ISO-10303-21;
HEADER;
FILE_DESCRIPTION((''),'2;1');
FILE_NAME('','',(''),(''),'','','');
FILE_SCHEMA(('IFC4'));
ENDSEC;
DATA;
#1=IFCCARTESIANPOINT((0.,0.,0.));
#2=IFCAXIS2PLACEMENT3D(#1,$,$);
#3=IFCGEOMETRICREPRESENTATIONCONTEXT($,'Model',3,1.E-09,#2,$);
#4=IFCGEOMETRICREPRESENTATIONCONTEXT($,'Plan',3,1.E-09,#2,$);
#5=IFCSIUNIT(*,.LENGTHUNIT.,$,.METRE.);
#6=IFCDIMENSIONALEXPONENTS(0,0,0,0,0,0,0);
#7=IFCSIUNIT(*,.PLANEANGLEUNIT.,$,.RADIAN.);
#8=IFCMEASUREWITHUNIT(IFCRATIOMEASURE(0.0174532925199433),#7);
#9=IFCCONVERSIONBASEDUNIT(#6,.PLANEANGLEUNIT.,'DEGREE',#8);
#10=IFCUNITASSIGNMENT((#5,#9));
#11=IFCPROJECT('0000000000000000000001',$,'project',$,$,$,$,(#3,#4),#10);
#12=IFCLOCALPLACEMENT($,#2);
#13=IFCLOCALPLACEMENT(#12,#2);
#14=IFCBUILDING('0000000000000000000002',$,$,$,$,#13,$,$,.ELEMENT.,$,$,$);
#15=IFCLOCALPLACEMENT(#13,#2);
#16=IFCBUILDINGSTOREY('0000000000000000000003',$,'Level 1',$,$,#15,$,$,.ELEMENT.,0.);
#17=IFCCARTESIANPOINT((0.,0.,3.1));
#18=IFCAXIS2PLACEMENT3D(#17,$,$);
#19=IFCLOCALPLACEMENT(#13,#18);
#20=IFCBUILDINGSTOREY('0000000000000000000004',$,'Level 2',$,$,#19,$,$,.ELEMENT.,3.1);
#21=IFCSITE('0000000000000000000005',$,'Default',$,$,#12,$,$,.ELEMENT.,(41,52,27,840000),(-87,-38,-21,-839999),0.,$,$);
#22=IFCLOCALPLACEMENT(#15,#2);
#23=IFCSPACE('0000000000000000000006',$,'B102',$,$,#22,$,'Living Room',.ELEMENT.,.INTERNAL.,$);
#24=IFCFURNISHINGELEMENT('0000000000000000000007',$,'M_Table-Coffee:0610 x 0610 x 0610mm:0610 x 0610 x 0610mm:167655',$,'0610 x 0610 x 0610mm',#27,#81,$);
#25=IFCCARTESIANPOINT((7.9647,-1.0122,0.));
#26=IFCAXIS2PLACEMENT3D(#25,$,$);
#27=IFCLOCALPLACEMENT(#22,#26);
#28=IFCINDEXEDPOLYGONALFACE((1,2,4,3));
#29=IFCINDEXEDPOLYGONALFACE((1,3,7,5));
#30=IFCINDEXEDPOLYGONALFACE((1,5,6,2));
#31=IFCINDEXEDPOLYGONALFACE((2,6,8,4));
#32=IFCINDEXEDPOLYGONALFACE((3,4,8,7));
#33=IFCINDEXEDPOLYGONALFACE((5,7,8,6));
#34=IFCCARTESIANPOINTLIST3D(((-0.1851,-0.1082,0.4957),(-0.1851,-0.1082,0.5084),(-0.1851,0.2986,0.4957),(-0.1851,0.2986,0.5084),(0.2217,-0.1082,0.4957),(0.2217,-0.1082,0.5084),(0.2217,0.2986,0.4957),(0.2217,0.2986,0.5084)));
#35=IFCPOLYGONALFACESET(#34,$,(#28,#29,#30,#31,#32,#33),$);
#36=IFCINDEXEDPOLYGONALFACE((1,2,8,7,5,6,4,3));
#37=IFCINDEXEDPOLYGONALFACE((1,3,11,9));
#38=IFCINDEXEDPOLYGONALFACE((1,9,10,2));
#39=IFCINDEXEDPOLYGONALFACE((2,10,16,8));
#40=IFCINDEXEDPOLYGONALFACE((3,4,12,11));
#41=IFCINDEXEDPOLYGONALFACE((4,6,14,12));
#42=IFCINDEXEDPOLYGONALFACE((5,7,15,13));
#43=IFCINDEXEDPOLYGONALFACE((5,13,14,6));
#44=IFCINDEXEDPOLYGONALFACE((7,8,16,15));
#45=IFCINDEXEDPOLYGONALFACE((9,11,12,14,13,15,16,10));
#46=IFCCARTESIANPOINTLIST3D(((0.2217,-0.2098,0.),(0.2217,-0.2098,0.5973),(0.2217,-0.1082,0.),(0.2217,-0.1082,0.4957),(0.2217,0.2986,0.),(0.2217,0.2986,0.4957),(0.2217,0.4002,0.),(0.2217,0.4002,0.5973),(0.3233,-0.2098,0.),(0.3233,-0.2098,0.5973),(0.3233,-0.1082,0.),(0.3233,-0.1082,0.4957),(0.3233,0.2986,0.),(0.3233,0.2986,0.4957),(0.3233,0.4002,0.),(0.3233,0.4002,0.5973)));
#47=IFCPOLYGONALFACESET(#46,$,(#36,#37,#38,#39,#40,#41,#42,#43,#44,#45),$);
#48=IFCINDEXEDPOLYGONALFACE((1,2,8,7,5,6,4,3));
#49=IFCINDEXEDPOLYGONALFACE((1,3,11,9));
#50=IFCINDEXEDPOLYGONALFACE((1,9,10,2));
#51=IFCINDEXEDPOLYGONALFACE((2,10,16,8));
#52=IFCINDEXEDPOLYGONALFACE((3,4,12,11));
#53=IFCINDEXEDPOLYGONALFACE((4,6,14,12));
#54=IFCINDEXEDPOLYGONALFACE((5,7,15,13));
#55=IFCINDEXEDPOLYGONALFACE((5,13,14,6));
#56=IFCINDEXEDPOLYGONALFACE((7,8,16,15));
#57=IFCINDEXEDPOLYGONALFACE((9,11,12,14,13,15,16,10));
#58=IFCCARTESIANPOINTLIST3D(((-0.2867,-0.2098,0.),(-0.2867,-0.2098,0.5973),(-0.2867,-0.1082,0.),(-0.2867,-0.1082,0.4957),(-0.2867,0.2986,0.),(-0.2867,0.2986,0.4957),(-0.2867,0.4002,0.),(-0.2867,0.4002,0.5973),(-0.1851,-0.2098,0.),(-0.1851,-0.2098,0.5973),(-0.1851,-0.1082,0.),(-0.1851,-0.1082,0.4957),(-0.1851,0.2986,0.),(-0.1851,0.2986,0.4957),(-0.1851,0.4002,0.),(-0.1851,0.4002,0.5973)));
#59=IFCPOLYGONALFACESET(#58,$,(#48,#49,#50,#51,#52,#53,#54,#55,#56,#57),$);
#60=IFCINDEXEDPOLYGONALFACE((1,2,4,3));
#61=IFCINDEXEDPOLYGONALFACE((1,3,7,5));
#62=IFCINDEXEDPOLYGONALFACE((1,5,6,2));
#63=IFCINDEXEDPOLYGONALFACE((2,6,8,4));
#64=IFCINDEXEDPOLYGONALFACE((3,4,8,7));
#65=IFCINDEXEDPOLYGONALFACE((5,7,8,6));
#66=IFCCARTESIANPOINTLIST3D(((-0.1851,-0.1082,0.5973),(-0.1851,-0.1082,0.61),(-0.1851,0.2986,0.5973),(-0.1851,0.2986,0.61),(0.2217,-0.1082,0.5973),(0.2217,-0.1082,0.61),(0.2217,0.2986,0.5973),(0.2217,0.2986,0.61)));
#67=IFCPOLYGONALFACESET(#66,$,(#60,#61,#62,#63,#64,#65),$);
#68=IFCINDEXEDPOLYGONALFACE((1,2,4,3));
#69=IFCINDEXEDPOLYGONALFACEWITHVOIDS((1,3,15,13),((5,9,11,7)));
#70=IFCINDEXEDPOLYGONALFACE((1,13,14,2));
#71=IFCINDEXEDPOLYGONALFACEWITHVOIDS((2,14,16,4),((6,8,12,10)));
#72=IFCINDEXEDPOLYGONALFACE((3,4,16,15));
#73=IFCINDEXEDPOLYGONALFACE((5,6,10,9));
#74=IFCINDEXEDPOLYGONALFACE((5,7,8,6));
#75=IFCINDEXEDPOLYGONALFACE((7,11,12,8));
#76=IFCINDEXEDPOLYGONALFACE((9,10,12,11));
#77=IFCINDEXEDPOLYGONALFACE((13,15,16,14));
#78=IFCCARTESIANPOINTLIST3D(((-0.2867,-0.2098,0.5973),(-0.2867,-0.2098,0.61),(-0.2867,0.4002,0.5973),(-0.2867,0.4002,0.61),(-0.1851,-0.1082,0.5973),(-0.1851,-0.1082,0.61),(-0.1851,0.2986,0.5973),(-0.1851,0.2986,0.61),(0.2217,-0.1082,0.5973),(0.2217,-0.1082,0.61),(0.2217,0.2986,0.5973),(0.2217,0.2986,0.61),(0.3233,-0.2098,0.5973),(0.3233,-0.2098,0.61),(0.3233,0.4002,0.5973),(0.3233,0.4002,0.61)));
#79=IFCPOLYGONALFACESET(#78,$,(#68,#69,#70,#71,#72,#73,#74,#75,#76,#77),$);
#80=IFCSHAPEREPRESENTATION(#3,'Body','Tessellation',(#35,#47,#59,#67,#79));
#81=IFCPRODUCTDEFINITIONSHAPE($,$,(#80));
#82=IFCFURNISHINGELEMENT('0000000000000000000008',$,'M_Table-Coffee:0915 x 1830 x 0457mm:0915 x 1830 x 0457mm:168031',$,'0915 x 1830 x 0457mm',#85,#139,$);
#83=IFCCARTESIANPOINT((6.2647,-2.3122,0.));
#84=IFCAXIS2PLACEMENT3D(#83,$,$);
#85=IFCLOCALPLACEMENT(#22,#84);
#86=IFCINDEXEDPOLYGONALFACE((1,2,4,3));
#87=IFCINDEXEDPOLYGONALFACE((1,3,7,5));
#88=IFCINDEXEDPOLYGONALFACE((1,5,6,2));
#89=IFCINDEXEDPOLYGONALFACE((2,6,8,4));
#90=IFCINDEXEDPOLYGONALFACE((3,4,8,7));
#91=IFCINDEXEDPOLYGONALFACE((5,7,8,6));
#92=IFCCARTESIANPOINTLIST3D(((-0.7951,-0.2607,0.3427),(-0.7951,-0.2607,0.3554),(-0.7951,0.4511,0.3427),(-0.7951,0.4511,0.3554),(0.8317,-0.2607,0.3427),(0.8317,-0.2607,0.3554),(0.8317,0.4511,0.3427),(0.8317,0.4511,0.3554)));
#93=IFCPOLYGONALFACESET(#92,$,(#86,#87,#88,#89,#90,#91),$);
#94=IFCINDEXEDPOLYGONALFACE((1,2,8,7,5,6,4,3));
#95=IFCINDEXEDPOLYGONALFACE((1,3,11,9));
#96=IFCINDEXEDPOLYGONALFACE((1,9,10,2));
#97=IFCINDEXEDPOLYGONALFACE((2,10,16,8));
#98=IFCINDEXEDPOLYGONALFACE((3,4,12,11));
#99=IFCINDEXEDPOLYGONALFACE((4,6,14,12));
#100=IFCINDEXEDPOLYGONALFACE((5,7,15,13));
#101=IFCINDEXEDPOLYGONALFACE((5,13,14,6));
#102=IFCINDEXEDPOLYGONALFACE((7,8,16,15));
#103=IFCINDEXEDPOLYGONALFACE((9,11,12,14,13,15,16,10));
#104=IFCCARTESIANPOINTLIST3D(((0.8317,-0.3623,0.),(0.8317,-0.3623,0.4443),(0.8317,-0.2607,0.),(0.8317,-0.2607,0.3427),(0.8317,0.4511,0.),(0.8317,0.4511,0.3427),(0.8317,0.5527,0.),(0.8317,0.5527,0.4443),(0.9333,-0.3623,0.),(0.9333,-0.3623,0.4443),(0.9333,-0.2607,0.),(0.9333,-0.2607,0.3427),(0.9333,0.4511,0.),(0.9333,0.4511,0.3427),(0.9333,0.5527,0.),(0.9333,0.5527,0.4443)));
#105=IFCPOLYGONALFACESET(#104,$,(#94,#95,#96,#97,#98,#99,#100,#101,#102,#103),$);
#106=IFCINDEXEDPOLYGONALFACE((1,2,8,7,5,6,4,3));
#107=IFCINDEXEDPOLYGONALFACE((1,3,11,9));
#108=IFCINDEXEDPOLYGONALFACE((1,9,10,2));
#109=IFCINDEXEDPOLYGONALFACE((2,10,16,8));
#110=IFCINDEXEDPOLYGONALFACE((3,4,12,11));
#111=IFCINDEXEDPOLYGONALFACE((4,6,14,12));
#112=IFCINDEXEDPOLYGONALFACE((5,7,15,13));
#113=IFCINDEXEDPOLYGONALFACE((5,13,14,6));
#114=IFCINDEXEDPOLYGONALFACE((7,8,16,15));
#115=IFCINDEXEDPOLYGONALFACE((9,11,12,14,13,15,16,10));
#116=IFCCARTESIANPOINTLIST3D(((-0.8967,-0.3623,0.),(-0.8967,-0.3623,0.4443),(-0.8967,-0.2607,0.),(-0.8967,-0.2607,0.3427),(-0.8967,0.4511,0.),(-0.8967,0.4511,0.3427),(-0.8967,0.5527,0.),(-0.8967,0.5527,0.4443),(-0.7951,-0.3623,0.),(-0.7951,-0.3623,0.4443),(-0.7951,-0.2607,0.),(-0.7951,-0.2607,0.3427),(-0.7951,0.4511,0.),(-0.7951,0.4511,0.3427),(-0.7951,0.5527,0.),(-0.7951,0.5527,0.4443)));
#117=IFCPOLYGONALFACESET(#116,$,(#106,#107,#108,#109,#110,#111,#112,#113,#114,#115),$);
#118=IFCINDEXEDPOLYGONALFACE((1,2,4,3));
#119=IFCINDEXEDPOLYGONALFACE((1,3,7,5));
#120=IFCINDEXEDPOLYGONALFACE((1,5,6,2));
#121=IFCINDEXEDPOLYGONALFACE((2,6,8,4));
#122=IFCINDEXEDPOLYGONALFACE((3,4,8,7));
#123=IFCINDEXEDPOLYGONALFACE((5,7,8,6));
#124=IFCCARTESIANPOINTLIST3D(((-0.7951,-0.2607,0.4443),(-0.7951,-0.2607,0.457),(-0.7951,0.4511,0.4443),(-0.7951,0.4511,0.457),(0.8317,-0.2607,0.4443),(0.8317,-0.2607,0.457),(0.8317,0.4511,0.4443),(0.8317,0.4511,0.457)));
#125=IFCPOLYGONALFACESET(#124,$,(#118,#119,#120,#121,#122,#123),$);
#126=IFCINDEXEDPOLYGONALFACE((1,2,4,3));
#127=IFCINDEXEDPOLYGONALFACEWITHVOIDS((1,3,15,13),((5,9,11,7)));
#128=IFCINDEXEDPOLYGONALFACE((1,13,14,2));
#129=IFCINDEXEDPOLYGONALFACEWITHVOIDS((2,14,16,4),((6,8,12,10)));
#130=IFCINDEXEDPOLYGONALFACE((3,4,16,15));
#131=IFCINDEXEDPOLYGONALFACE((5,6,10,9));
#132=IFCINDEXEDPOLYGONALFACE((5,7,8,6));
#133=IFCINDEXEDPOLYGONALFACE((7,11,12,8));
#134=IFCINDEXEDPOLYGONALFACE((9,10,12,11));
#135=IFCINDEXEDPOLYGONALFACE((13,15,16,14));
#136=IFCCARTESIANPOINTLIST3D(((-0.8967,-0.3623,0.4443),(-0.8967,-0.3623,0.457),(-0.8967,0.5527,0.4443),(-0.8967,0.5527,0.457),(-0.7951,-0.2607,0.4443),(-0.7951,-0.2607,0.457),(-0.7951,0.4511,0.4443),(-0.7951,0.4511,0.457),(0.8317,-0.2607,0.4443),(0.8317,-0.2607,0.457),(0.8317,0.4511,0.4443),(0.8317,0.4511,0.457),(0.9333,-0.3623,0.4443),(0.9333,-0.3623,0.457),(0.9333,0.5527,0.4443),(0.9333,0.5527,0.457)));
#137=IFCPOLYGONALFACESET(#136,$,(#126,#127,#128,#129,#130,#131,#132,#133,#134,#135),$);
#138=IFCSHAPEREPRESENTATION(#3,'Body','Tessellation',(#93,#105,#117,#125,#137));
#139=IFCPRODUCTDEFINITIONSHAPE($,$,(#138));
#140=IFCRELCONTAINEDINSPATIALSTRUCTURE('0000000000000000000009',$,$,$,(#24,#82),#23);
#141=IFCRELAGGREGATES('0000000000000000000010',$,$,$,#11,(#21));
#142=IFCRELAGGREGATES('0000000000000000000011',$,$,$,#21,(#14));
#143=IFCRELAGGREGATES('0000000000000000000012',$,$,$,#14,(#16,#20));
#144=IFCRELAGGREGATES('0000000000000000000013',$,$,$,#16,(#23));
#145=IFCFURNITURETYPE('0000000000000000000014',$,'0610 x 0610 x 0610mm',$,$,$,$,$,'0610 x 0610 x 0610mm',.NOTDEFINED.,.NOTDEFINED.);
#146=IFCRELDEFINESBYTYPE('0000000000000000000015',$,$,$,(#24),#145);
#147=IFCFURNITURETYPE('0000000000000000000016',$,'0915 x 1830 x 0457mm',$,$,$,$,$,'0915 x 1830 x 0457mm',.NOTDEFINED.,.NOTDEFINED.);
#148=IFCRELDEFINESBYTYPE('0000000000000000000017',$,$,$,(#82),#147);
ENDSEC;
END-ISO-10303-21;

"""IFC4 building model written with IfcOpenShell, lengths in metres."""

from ifc_helpers import new_model, entity, si_unit, converted_unit, frame, origin, origin_2d_with_axis, place, context, project, spatial, polyline, rectangle, outline, extrude, source, transform, mapped, type_object, type_shapes, element, save


model = new_model("IFC4")

# Units and contexts
model_context = context("Model", 3, precision=1e-09, world=origin())
plan_context = context("Plan", 3, precision=1e-09, world=origin())
ifc_project = project(units=[si_unit("LENGTHUNIT", "METRE"), converted_unit("PLANEANGLEUNIT", "DEGREE", entity("IfcRatioMeasure", 0.0174532925199433), si_unit("PLANEANGLEUNIT", "RADIAN"), dimensions=[0, 0, 0, 0, 0, 0, 0])], contexts=[model_context, plan_context])

# Site, building, storey
site_placement = place(None, origin())
site = spatial("IfcSite", under=ifc_project, at=site_placement, Name="Default", CompositionType="ELEMENT", RefLatitude=(41, 52, 27, 840000), RefLongitude=(-87, -38, -21, -839999), RefElevation=0.0)
building_placement = place(site_placement, origin())
building = spatial("IfcBuilding", under=site, at=building_placement, CompositionType="ELEMENT")
storey_1_placement = place(building_placement, origin())
storey_1 = spatial("IfcBuildingStorey", under=building, at=storey_1_placement, Name="Level 1", CompositionType="ELEMENT", Elevation=0.0)

# Shared definitions
storey_2_placement = place(building_placement, frame((0.0, 0.0, 3.1)))
storey_2 = spatial("IfcBuildingStorey", under=building, at=storey_2_placement, Name="Level 2", CompositionType="ELEMENT", Elevation=3.1)

# Shared definitions
space_1_placement = place(storey_1_placement, origin())
space_1 = spatial("IfcSpace", under=storey_1, at=space_1_placement, Name="B102", LongName="Living Room", CompositionType="ELEMENT", PredefinedType="INTERNAL")

# Furnishing elements
furniture_type_1 = type_object("IfcFurnitureType", Name="0610 x 0610 x 0610mm", ElementType="0610 x 0610 x 0610mm", AssemblyPlace="NOTDEFINED")
shared_shape_1 = source(origin(), model_context, "Body", "SweptSolid", [
    extrude(rectangle(XDim=0.4068, YDim=0.4068, at=origin_2d_with_axis()), frame((0.0183, 0.0952, 0.4957), z_axis=(0.0, 0.0, 1.0), x_axis=(-1.0, 0.0, 0.0)), (0.0, 0.0, 1.0), 0.0127),
    extrude(outline(polyline([(-0.2732, -0.305), (0.324, -0.305), (0.324, 0.305), (-0.2732, 0.305), (-0.2732, 0.2034), (0.2225, 0.2034), (0.2225, -0.2034), (-0.2732, -0.2034), (-0.2732, -0.305)])), frame((0.2217, 0.0952, 0.2732), z_axis=(1.0, 0.0, 0.0), x_axis=(0.0, 0.0, 1.0)), (0.0, 0.0, 1.0), 0.1016),
    extrude(outline(polyline([(-0.305, -0.3241), (0.305, -0.3241), (0.305, 0.2733), (0.2034, 0.2733), (0.2034, -0.2224), (-0.2034, -0.2224), (-0.2034, 0.2733), (-0.305, 0.2733), (-0.305, -0.3241)])), frame((-0.2867, 0.0952, 0.2733), z_axis=(1.0, 0.0, 0.0), x_axis=(0.0, -1.0, 0.0)), (0.0, 0.0, 1.0), 0.1016),
    extrude(rectangle(XDim=0.4068, YDim=0.4068, at=origin_2d_with_axis()), frame((0.0183, 0.0952, 0.5973), z_axis=(0.0, 0.0, 1.0), x_axis=(-1.0, 0.0, 0.0)), (0.0, 0.0, 1.0), 0.0127),
    extrude(outline(polyline([(-0.305, -0.305), (0.305, -0.305), (0.305, 0.305), (-0.305, 0.305), (-0.305, -0.305)]), holes=[polyline([(-0.2034, -0.2034), (-0.2034, 0.2034), (0.2034, 0.2034), (0.2034, -0.2034), (-0.2034, -0.2034)])]), frame((0.0183, 0.0952, 0.5973), z_axis=(0.0, 0.0, 1.0), x_axis=(-1.0, 0.0, 0.0)), (0.0, 0.0, 1.0), 0.0127),
])
type_shapes(furniture_type_1, [shared_shape_1])
for number, where, name in (
    (1, (7.9647, -1.0122, 0.0), "M_Table-Coffee:0610 x 0610 x 0610mm:0610 x 0610 x 0610mm:167655"),
):
    element("IfcFurnishingElement", number, at=place(space_1_placement, frame(where)), inside=space_1, type_object=furniture_type_1, Name=name, ObjectType="0610 x 0610 x 0610mm", context=model_context, shape_type="MappedRepresentation", body=[
        mapped(shared_shape_1, transform((0.0, 0.0, 0.0), scale=1.0)),
    ])
furniture_type_2 = type_object("IfcFurnitureType", Name="0915 x 1830 x 0457mm", ElementType="0915 x 1830 x 0457mm", AssemblyPlace="NOTDEFINED")
shared_shape_2 = source(origin(), model_context, "Body", "SweptSolid", [
    extrude(rectangle(XDim=1.6268, YDim=0.7118, at=origin_2d_with_axis()), frame((0.0183, 0.0952, 0.3427), z_axis=(0.0, 0.0, 1.0), x_axis=(-1.0, 0.0, 0.0)), (0.0, 0.0, 1.0), 0.0127),
    extrude(outline(polyline([(-0.1967, -0.4575), (0.2475, -0.4575), (0.2475, 0.4575), (-0.1967, 0.4575), (-0.1967, 0.3559), (0.146, 0.3559), (0.146, -0.3559), (-0.1967, -0.3559), (-0.1967, -0.4575)])), frame((0.8317, 0.0952, 0.1967), z_axis=(1.0, 0.0, 0.0), x_axis=(0.0, 0.0, 1.0)), (0.0, 0.0, 1.0), 0.1016),
    extrude(outline(polyline([(-0.4575, -0.2476), (0.4575, -0.2476), (0.4575, 0.1968), (0.3559, 0.1968), (0.3559, -0.1459), (-0.3559, -0.1459), (-0.3559, 0.1968), (-0.4575, 0.1968), (-0.4575, -0.2476)])), frame((-0.8967, 0.0952, 0.1968), z_axis=(1.0, 0.0, 0.0), x_axis=(0.0, -1.0, 0.0)), (0.0, 0.0, 1.0), 0.1016),
    extrude(rectangle(XDim=1.6268, YDim=0.7118, at=origin_2d_with_axis()), frame((0.0183, 0.0952, 0.4443), z_axis=(0.0, 0.0, 1.0), x_axis=(-1.0, 0.0, 0.0)), (0.0, 0.0, 1.0), 0.0127),
    extrude(outline(polyline([(-0.915, -0.4575), (0.915, -0.4575), (0.915, 0.4575), (-0.915, 0.4575), (-0.915, -0.4575)]), holes=[polyline([(-0.8134, -0.3559), (-0.8134, 0.3559), (0.8134, 0.3559), (0.8134, -0.3559), (-0.8134, -0.3559)])]), frame((0.0183, 0.0952, 0.4443), z_axis=(0.0, 0.0, 1.0), x_axis=(-1.0, 0.0, 0.0)), (0.0, 0.0, 1.0), 0.0127),
])
type_shapes(furniture_type_2, [shared_shape_2])
furnishing_1_placement = place(space_1_placement, frame((6.2647, -2.3122, 0.0)))
element("IfcFurnishingElement", 2, at=furnishing_1_placement, inside=space_1, type_object=furniture_type_2, Name="M_Table-Coffee:0915 x 1830 x 0457mm:0915 x 1830 x 0457mm:168031", ObjectType="0915 x 1830 x 0457mm", context=model_context, shape_type="MappedRepresentation", body=[
    mapped(shared_shape_2, transform((0.0, 0.0, 0.0), scale=1.0)),
])

save(model, "model.ifc")
